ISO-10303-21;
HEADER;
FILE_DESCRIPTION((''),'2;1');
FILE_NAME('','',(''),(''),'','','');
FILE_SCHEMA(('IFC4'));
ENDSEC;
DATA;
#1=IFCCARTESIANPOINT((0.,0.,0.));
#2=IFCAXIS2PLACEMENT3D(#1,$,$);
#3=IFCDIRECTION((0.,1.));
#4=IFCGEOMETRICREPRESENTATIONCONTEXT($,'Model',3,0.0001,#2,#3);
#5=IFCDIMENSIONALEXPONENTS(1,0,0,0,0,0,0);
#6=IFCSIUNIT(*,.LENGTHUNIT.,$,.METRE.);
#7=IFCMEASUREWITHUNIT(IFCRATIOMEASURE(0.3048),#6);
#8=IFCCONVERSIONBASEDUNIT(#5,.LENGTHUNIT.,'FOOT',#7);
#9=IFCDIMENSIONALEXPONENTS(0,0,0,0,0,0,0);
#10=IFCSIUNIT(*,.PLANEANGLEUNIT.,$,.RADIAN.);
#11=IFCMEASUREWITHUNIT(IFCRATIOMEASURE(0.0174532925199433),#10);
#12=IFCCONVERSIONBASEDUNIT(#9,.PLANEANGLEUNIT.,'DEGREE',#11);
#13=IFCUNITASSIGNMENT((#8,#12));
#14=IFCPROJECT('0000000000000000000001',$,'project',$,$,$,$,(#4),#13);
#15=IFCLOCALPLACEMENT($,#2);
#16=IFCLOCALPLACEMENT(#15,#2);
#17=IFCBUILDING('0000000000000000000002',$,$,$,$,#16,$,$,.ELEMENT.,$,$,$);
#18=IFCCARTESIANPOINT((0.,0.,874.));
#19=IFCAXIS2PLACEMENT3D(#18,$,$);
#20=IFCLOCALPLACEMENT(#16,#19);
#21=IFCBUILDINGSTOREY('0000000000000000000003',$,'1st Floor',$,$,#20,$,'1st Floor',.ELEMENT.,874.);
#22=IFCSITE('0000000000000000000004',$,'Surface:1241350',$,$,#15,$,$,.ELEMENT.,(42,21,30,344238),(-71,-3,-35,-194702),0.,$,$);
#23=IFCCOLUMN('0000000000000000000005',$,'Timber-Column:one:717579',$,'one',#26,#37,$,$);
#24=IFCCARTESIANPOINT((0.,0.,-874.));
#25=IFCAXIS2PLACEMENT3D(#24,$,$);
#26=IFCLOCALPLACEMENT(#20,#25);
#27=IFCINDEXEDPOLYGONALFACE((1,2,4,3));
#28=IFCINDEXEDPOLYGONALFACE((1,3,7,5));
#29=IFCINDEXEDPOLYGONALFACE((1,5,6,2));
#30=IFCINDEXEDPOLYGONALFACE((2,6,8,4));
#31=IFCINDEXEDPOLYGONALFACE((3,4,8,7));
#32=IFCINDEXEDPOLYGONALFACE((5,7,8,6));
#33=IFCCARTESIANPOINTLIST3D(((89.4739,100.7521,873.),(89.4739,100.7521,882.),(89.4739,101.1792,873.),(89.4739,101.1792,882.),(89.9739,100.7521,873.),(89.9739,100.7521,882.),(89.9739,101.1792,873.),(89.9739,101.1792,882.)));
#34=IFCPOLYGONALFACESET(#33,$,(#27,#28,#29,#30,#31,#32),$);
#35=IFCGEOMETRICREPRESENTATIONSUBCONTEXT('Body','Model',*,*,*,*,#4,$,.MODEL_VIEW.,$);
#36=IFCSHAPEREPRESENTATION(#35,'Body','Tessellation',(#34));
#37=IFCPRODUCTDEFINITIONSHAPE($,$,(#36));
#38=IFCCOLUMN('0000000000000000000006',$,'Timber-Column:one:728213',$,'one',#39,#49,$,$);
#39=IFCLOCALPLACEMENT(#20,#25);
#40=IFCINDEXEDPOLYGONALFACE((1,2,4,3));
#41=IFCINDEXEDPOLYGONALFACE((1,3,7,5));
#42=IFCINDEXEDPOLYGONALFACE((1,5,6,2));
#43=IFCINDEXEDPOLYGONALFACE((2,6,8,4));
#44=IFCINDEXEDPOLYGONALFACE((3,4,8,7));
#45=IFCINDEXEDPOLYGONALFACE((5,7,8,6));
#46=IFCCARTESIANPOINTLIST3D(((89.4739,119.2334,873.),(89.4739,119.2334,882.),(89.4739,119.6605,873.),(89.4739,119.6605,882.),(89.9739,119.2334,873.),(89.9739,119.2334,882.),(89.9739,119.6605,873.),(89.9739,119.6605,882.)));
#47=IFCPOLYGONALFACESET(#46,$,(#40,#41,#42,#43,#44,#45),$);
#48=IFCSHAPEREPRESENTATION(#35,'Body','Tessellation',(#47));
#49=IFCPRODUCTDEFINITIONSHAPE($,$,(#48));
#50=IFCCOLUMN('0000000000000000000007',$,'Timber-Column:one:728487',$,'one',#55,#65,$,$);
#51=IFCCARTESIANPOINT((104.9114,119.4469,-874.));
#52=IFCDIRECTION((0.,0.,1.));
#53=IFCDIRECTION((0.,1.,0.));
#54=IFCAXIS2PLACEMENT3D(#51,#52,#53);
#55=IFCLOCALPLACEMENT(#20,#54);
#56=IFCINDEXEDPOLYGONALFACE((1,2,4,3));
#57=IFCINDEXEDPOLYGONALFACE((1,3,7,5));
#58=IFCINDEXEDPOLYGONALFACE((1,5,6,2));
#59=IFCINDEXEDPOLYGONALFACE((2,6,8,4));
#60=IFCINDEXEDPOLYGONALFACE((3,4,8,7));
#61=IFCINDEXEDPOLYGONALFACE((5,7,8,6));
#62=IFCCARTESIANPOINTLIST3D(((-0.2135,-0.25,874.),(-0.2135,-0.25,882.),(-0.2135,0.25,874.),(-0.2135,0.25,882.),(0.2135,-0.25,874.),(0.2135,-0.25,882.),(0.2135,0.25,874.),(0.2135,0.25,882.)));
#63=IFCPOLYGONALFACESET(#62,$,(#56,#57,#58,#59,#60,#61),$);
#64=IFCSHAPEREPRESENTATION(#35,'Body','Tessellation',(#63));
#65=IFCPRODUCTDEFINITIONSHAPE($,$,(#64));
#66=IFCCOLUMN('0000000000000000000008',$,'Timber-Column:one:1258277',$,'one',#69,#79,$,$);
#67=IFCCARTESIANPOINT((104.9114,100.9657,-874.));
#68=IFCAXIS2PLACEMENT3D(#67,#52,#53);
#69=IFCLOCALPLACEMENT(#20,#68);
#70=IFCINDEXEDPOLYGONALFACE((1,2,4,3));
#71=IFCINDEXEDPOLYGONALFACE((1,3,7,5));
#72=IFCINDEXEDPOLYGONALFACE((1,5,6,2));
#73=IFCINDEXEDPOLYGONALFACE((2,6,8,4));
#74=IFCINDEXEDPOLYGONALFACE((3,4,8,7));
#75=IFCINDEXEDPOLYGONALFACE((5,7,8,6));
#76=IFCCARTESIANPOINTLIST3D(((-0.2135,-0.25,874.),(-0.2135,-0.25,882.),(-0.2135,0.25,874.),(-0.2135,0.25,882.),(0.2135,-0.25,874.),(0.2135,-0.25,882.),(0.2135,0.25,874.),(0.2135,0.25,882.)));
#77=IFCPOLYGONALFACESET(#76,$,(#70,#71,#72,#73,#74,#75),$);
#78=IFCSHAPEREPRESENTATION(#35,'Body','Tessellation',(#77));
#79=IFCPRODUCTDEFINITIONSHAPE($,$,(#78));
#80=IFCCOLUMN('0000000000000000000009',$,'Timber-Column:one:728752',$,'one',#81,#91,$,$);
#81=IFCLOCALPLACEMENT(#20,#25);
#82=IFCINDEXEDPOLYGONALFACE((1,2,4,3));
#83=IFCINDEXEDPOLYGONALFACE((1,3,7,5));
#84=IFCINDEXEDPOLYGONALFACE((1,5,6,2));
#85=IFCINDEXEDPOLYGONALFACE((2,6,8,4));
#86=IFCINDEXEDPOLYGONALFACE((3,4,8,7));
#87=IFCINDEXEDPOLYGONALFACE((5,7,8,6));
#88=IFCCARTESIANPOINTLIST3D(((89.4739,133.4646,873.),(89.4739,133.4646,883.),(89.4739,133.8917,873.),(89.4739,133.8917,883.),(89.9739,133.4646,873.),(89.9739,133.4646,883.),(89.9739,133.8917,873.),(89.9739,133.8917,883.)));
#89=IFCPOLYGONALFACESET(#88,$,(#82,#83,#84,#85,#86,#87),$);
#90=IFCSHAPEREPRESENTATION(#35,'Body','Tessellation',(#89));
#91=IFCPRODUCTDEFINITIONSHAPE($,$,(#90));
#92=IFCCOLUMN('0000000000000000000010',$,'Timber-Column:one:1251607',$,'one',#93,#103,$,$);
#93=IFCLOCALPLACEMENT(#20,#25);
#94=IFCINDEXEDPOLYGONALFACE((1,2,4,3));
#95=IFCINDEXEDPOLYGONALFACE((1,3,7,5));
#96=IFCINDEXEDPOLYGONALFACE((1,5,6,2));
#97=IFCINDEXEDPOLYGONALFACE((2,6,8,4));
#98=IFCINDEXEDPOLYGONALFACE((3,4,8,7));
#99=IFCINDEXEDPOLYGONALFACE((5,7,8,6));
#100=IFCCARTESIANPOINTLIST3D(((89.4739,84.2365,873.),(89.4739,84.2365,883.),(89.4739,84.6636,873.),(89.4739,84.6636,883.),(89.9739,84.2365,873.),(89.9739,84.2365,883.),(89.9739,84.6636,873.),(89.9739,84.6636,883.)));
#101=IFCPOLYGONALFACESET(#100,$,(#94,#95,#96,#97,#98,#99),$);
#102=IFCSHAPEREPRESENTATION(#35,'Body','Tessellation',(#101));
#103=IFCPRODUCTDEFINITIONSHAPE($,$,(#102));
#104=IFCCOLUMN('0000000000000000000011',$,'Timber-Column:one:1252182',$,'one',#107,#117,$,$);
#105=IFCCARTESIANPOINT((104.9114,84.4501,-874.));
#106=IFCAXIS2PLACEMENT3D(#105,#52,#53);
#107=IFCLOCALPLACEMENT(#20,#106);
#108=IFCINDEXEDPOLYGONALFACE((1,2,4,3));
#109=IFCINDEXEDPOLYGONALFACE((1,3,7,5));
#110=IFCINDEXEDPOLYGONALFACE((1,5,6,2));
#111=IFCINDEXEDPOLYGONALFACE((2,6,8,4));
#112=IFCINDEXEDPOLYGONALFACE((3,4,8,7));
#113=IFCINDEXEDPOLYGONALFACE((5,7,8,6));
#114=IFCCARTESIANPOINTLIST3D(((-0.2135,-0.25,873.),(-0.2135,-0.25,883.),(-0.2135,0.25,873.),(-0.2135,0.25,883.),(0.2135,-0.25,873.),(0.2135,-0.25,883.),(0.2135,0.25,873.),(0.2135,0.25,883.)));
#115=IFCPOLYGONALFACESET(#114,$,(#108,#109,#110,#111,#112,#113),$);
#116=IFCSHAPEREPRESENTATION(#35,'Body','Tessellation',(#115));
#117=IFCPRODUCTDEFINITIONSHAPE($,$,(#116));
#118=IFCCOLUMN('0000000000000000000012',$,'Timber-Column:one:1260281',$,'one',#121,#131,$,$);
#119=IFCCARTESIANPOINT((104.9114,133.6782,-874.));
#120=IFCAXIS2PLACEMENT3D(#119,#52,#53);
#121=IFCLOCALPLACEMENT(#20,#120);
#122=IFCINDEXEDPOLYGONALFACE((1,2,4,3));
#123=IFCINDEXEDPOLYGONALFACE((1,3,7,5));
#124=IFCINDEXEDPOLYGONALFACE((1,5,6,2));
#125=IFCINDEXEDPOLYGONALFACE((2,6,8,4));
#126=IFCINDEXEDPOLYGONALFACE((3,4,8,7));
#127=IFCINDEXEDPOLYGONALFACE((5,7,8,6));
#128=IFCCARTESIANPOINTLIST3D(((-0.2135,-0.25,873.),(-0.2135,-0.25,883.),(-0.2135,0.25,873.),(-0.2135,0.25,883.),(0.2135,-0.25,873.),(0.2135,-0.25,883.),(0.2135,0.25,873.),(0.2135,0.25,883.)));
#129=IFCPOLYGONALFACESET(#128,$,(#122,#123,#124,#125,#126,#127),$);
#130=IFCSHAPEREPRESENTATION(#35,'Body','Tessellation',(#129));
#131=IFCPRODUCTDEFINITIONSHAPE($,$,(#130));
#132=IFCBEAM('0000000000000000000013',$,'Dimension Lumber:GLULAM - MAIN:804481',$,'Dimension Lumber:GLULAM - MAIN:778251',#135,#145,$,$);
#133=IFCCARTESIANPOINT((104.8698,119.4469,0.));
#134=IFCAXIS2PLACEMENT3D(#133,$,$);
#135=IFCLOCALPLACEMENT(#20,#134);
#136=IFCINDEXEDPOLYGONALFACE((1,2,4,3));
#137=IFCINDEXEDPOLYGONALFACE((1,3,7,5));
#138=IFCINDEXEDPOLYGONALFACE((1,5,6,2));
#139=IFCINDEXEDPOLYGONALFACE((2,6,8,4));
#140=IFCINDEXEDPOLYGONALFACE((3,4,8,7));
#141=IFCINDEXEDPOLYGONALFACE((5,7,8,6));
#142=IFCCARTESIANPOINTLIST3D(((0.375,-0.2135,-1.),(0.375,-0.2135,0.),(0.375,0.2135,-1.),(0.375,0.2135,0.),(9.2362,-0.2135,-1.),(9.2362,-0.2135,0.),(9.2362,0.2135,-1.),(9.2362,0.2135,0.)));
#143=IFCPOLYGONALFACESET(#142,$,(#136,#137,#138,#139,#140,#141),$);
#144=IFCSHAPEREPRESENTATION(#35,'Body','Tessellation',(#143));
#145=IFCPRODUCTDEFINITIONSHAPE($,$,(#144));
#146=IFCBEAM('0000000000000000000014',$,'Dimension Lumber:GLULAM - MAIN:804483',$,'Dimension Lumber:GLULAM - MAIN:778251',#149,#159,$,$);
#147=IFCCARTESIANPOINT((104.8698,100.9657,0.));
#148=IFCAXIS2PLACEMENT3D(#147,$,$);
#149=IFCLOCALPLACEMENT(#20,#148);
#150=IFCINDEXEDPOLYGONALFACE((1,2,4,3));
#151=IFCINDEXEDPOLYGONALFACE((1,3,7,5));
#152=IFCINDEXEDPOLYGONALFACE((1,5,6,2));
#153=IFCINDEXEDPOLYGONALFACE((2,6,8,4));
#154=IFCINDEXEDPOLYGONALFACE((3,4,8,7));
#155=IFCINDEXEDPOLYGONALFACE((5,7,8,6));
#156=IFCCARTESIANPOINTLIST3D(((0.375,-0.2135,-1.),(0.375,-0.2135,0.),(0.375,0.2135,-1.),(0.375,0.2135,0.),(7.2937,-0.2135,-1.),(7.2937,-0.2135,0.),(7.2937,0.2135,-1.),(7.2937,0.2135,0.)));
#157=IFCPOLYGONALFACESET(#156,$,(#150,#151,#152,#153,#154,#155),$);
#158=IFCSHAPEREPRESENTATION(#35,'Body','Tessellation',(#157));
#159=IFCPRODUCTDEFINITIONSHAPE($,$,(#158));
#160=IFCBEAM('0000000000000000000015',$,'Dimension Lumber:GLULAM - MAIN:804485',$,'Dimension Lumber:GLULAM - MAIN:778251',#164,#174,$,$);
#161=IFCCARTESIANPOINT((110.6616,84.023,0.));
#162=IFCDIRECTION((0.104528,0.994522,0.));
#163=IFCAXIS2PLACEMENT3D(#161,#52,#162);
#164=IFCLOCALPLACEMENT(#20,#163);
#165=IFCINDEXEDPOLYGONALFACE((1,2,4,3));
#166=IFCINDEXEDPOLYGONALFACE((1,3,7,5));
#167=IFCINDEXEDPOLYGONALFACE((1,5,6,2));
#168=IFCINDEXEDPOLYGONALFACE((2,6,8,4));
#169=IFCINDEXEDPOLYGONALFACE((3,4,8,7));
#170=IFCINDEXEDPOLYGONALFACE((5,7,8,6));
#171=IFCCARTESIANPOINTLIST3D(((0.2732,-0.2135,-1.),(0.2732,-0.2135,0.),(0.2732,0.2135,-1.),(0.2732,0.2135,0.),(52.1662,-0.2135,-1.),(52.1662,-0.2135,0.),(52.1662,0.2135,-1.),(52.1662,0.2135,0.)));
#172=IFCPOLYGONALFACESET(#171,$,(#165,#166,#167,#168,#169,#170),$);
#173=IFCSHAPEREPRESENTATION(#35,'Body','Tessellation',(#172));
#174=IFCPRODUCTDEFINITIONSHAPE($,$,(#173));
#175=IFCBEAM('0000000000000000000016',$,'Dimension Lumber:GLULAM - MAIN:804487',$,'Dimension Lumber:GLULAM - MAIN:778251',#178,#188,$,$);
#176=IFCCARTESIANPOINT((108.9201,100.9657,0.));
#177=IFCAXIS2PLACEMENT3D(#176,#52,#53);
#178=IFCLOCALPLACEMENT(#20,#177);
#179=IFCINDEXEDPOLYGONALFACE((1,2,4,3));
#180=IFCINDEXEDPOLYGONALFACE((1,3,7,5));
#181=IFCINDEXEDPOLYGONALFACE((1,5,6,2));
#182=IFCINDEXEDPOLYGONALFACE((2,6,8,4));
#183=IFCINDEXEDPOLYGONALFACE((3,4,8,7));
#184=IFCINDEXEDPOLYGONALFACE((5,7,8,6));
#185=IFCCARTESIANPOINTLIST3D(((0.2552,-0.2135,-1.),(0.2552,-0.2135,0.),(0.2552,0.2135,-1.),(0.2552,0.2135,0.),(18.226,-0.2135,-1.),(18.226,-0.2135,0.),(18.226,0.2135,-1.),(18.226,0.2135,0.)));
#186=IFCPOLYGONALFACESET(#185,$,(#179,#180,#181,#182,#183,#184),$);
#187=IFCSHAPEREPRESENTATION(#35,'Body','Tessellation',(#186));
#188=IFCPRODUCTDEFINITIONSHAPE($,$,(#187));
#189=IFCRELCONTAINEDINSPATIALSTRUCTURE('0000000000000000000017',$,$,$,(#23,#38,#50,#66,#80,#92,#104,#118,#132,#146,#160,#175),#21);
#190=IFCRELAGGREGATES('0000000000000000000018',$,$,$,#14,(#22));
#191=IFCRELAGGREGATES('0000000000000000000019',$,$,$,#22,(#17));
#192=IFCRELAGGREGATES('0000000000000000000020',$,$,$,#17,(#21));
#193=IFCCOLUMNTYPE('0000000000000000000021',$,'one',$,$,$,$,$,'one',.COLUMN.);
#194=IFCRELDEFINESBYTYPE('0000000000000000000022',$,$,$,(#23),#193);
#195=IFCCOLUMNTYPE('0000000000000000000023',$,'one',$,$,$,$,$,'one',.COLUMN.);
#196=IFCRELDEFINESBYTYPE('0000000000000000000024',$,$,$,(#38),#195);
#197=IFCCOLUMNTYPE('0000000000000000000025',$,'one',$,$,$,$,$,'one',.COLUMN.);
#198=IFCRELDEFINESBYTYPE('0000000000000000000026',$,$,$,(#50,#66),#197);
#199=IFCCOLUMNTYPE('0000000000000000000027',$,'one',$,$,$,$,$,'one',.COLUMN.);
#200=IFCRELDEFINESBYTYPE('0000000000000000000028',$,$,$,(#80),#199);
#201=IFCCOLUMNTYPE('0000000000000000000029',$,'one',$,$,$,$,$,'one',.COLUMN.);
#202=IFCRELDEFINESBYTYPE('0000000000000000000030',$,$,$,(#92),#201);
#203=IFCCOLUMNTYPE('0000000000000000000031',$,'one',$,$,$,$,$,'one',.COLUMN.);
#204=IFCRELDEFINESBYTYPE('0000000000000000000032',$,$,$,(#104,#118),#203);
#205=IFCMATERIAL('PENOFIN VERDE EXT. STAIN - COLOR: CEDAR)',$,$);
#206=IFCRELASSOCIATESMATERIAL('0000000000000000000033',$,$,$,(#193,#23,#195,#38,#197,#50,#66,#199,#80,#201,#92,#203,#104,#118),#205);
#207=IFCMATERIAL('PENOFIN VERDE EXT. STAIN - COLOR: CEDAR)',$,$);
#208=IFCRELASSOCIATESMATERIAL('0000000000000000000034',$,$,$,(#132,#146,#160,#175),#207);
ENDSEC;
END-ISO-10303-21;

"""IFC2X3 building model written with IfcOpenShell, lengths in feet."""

from ifc_helpers import new_model, entity, si_unit, converted_unit, direction, frame, frame_2d, origin, origin_2d_with_axis, place, context, subcontext, project, spatial, rectangle, extrude, source, transform, mapped, material, type_object, type_shapes, element, save


model = new_model("IFC2X3")

# Units and contexts
model_context = context("Model", 3, precision=0.0001, world=origin(), true_north=direction((0.0, 1.0)))
body_context = subcontext(model_context, "Body", "Model", "MODEL_VIEW")
ifc_project = project(units=[converted_unit("LENGTHUNIT", "FOOT", entity("IfcRatioMeasure", 0.3048), si_unit("LENGTHUNIT", "METRE"), dimensions=[1, 0, 0, 0, 0, 0, 0]), converted_unit("PLANEANGLEUNIT", "DEGREE", entity("IfcRatioMeasure", 0.0174532925199433), si_unit("PLANEANGLEUNIT", "RADIAN"), dimensions=[0, 0, 0, 0, 0, 0, 0])], contexts=[model_context])

# Site, building, storey
site_placement = place(None, origin())
site = spatial("IfcSite", under=ifc_project, at=site_placement, Name="Surface:1241350", CompositionType="ELEMENT", RefLatitude=(42, 21, 30, 344238), RefLongitude=(-71, -3, -35, -194702), RefElevation=0.0)
building_placement = place(site_placement, origin())
building = spatial("IfcBuilding", under=site, at=building_placement, CompositionType="ELEMENT")
storey_placement = place(building_placement, frame((0.0, 0.0, 874.0)))
storey = spatial("IfcBuildingStorey", under=building, at=storey_placement, Name="1st Floor", LongName="1st Floor", CompositionType="ELEMENT", Elevation=874.0)

# Columns
ifc_material_1 = material(Name="PENOFIN VERDE EXT. STAIN - COLOR: CEDAR)")
column_type_1 = type_object("IfcColumnType", Name="one", ElementType="one", PredefinedType="COLUMN", material=ifc_material_1)
shared_shape_1 = source(origin(), body_context, "Body", "SweptSolid", [
    extrude(rectangle(XDim=0.4271, YDim=0.5, at=origin_2d_with_axis()), frame((89.7239, 100.9657, 873.0), z_axis=(0.0, 0.0, 1.0), x_axis=(0.0, -1.0, 0.0)), (0.0, 0.0, 1.0), 9.0),
])
type_shapes(column_type_1, [shared_shape_1])
column_1_placement = place(storey_placement, frame((0.0, 0.0, -874.0)))
element("IfcColumn", 1, at=column_1_placement, inside=storey, type_object=column_type_1, material=ifc_material_1, Name="Timber-Column:one:717579", ObjectType="one", context=body_context, shape_type="MappedRepresentation", body=[
    mapped(shared_shape_1, transform((0.0, 0.0, 0.0), scale=1.0)),
])
column_type_2 = type_object("IfcColumnType", Name="one", ElementType="one", PredefinedType="COLUMN", material=ifc_material_1)
shared_shape_2 = source(origin(), body_context, "Body", "SweptSolid", [
    extrude(rectangle(XDim=0.4271, YDim=0.5, at=origin_2d_with_axis()), frame((89.7239, 119.4469, 873.0), z_axis=(0.0, 0.0, 1.0), x_axis=(0.0, -1.0, 0.0)), (0.0, 0.0, 1.0), 9.0),
])
type_shapes(column_type_2, [shared_shape_2])
column_2_placement = place(storey_placement, frame((0.0, 0.0, -874.0)))
element("IfcColumn", 2, at=column_2_placement, inside=storey, type_object=column_type_2, material=ifc_material_1, Name="Timber-Column:one:728213", ObjectType="one", context=body_context, shape_type="MappedRepresentation", body=[
    mapped(shared_shape_2, transform((0.0, 0.0, 0.0), scale=1.0)),
])
column_type_3 = type_object("IfcColumnType", Name="one", ElementType="one", PredefinedType="COLUMN", material=ifc_material_1)
shared_shape_3 = source(origin(), body_context, "Body", "SweptSolid", [
    extrude(rectangle(XDim=0.5, YDim=0.4271, at=origin_2d_with_axis()), frame((0.0, 0.0, 874.0), z_axis=(0.0, 0.0, 1.0), x_axis=(0.0, -1.0, 0.0)), (0.0, 0.0, 1.0), 8.0),
])
type_shapes(column_type_3, [shared_shape_3])
for number, where, z_axis, x_axis, name in (
    (3, (104.9114, 119.4469, -874.0), (0.0, 0.0, 1.0), (0.0, 1.0, 0.0), "Timber-Column:one:728487"),
    (4, (104.9114, 100.9657, -874.0), (0.0, 0.0, 1.0), (0.0, 1.0, 0.0), "Timber-Column:one:1258277"),
):
    element("IfcColumn", number, at=place(storey_placement, frame(where, z_axis=z_axis, x_axis=x_axis)), inside=storey, type_object=column_type_3, material=ifc_material_1, Name=name, ObjectType="one", context=body_context, shape_type="MappedRepresentation", body=[
        mapped(shared_shape_3, transform((0.0, 0.0, 0.0), scale=1.0)),
    ])
column_type_4 = type_object("IfcColumnType", Name="one", ElementType="one", PredefinedType="COLUMN", material=ifc_material_1)
shared_shape_4 = source(origin(), body_context, "Body", "SweptSolid", [
    extrude(rectangle(XDim=0.4271, YDim=0.5, at=origin_2d_with_axis()), frame((89.7239, 133.6782, 873.0), z_axis=(0.0, 0.0, 1.0), x_axis=(0.0, -1.0, 0.0)), (0.0, 0.0, 1.0), 10.0),
])
type_shapes(column_type_4, [shared_shape_4])
column_3_placement = place(storey_placement, frame((0.0, 0.0, -874.0)))
element("IfcColumn", 5, at=column_3_placement, inside=storey, type_object=column_type_4, material=ifc_material_1, Name="Timber-Column:one:728752", ObjectType="one", context=body_context, shape_type="MappedRepresentation", body=[
    mapped(shared_shape_4, transform((0.0, 0.0, 0.0), scale=1.0)),
])
column_type_5 = type_object("IfcColumnType", Name="one", ElementType="one", PredefinedType="COLUMN", material=ifc_material_1)
shared_shape_5 = source(origin(), body_context, "Body", "SweptSolid", [
    extrude(rectangle(XDim=0.4271, YDim=0.5, at=origin_2d_with_axis()), frame((89.7239, 84.4501, 873.0), z_axis=(0.0, 0.0, 1.0), x_axis=(0.0, -1.0, 0.0)), (0.0, 0.0, 1.0), 10.0),
])
type_shapes(column_type_5, [shared_shape_5])
column_4_placement = place(storey_placement, frame((0.0, 0.0, -874.0)))
element("IfcColumn", 6, at=column_4_placement, inside=storey, type_object=column_type_5, material=ifc_material_1, Name="Timber-Column:one:1251607", ObjectType="one", context=body_context, shape_type="MappedRepresentation", body=[
    mapped(shared_shape_5, transform((0.0, 0.0, 0.0), scale=1.0)),
])
column_type_6 = type_object("IfcColumnType", Name="one", ElementType="one", PredefinedType="COLUMN", material=ifc_material_1)
shared_shape_6 = source(origin(), body_context, "Body", "SweptSolid", [
    extrude(rectangle(XDim=0.5, YDim=0.4271, at=origin_2d_with_axis()), frame((0.0, 0.0, 873.0), z_axis=(0.0, 0.0, 1.0), x_axis=(0.0, -1.0, 0.0)), (0.0, 0.0, 1.0), 10.0),
])
type_shapes(column_type_6, [shared_shape_6])
for number, where, z_axis, x_axis, name in (
    (7, (104.9114, 84.4501, -874.0), (0.0, 0.0, 1.0), (0.0, 1.0, 0.0), "Timber-Column:one:1252182"),
    (8, (104.9114, 133.6782, -874.0), (0.0, 0.0, 1.0), (0.0, 1.0, 0.0), "Timber-Column:one:1260281"),
):
    element("IfcColumn", number, at=place(storey_placement, frame(where, z_axis=z_axis, x_axis=x_axis)), inside=storey, type_object=column_type_6, material=ifc_material_1, Name=name, ObjectType="one", context=body_context, shape_type="MappedRepresentation", body=[
        mapped(shared_shape_6, transform((0.0, 0.0, 0.0), scale=1.0)),
    ])

# Beams
ifc_material_2 = material(Name="PENOFIN VERDE EXT. STAIN - COLOR: CEDAR)")
beam_1_placement = place(storey_placement, frame((104.8698, 119.4469, 0.0)))
element("IfcBeam", 9, at=beam_1_placement, inside=storey, material=ifc_material_2, Name="Dimension Lumber:GLULAM - MAIN:804481", ObjectType="Dimension Lumber:GLULAM - MAIN:778251", context=body_context, shape_type="SweptSolid", body=[
    extrude(rectangle(XDim=1.0, YDim=0.4271, at=frame_2d((0.0, 0.0), x_axis=(1.0, 0.0))), frame((0.375, 0.0, -0.5), z_axis=(1.0, 0.0, 0.0), x_axis=(0.0, 0.0, -1.0)), (0.0, 0.0, 1.0), 8.8612),
])
beam_2_placement = place(storey_placement, frame((104.8698, 100.9657, 0.0)))
element("IfcBeam", 10, at=beam_2_placement, inside=storey, material=ifc_material_2, Name="Dimension Lumber:GLULAM - MAIN:804483", ObjectType="Dimension Lumber:GLULAM - MAIN:778251", context=body_context, shape_type="SweptSolid", body=[
    extrude(rectangle(XDim=1.0, YDim=0.4271, at=frame_2d((0.0, 0.0), x_axis=(1.0, 0.0))), frame((0.375, 0.0, -0.5), z_axis=(1.0, 0.0, 0.0), x_axis=(0.0, 0.0, -1.0)), (0.0, 0.0, 1.0), 6.9187),
])
beam_3_placement = place(storey_placement, frame((110.6616, 84.023, 0.0), z_axis=(0.0, 0.0, 1.0), x_axis=(0.104528, 0.994522, 0.0)))
element("IfcBeam", 11, at=beam_3_placement, inside=storey, material=ifc_material_2, Name="Dimension Lumber:GLULAM - MAIN:804485", ObjectType="Dimension Lumber:GLULAM - MAIN:778251", context=body_context, shape_type="SweptSolid", body=[
    extrude(rectangle(XDim=1.0, YDim=0.4271, at=origin_2d_with_axis()), frame((0.2732, 0.0, -0.5), z_axis=(1.0, 0.0, 0.0), x_axis=(0.0, 0.0, -1.0)), (0.0, 0.0, 1.0), 51.893),
])
beam_4_placement = place(storey_placement, frame((108.9201, 100.9657, 0.0), z_axis=(0.0, 0.0, 1.0), x_axis=(0.0, 1.0, 0.0)))
element("IfcBeam", 12, at=beam_4_placement, inside=storey, material=ifc_material_2, Name="Dimension Lumber:GLULAM - MAIN:804487", ObjectType="Dimension Lumber:GLULAM - MAIN:778251", context=body_context, shape_type="SweptSolid", body=[
    extrude(rectangle(XDim=1.0, YDim=0.4271, at=origin_2d_with_axis()), frame((0.2552, 0.0, -0.5), z_axis=(1.0, 0.0, 0.0), x_axis=(0.0, 0.0, -1.0)), (0.0, 0.0, 1.0), 17.9708),
])

save(model, "model.ifc")
